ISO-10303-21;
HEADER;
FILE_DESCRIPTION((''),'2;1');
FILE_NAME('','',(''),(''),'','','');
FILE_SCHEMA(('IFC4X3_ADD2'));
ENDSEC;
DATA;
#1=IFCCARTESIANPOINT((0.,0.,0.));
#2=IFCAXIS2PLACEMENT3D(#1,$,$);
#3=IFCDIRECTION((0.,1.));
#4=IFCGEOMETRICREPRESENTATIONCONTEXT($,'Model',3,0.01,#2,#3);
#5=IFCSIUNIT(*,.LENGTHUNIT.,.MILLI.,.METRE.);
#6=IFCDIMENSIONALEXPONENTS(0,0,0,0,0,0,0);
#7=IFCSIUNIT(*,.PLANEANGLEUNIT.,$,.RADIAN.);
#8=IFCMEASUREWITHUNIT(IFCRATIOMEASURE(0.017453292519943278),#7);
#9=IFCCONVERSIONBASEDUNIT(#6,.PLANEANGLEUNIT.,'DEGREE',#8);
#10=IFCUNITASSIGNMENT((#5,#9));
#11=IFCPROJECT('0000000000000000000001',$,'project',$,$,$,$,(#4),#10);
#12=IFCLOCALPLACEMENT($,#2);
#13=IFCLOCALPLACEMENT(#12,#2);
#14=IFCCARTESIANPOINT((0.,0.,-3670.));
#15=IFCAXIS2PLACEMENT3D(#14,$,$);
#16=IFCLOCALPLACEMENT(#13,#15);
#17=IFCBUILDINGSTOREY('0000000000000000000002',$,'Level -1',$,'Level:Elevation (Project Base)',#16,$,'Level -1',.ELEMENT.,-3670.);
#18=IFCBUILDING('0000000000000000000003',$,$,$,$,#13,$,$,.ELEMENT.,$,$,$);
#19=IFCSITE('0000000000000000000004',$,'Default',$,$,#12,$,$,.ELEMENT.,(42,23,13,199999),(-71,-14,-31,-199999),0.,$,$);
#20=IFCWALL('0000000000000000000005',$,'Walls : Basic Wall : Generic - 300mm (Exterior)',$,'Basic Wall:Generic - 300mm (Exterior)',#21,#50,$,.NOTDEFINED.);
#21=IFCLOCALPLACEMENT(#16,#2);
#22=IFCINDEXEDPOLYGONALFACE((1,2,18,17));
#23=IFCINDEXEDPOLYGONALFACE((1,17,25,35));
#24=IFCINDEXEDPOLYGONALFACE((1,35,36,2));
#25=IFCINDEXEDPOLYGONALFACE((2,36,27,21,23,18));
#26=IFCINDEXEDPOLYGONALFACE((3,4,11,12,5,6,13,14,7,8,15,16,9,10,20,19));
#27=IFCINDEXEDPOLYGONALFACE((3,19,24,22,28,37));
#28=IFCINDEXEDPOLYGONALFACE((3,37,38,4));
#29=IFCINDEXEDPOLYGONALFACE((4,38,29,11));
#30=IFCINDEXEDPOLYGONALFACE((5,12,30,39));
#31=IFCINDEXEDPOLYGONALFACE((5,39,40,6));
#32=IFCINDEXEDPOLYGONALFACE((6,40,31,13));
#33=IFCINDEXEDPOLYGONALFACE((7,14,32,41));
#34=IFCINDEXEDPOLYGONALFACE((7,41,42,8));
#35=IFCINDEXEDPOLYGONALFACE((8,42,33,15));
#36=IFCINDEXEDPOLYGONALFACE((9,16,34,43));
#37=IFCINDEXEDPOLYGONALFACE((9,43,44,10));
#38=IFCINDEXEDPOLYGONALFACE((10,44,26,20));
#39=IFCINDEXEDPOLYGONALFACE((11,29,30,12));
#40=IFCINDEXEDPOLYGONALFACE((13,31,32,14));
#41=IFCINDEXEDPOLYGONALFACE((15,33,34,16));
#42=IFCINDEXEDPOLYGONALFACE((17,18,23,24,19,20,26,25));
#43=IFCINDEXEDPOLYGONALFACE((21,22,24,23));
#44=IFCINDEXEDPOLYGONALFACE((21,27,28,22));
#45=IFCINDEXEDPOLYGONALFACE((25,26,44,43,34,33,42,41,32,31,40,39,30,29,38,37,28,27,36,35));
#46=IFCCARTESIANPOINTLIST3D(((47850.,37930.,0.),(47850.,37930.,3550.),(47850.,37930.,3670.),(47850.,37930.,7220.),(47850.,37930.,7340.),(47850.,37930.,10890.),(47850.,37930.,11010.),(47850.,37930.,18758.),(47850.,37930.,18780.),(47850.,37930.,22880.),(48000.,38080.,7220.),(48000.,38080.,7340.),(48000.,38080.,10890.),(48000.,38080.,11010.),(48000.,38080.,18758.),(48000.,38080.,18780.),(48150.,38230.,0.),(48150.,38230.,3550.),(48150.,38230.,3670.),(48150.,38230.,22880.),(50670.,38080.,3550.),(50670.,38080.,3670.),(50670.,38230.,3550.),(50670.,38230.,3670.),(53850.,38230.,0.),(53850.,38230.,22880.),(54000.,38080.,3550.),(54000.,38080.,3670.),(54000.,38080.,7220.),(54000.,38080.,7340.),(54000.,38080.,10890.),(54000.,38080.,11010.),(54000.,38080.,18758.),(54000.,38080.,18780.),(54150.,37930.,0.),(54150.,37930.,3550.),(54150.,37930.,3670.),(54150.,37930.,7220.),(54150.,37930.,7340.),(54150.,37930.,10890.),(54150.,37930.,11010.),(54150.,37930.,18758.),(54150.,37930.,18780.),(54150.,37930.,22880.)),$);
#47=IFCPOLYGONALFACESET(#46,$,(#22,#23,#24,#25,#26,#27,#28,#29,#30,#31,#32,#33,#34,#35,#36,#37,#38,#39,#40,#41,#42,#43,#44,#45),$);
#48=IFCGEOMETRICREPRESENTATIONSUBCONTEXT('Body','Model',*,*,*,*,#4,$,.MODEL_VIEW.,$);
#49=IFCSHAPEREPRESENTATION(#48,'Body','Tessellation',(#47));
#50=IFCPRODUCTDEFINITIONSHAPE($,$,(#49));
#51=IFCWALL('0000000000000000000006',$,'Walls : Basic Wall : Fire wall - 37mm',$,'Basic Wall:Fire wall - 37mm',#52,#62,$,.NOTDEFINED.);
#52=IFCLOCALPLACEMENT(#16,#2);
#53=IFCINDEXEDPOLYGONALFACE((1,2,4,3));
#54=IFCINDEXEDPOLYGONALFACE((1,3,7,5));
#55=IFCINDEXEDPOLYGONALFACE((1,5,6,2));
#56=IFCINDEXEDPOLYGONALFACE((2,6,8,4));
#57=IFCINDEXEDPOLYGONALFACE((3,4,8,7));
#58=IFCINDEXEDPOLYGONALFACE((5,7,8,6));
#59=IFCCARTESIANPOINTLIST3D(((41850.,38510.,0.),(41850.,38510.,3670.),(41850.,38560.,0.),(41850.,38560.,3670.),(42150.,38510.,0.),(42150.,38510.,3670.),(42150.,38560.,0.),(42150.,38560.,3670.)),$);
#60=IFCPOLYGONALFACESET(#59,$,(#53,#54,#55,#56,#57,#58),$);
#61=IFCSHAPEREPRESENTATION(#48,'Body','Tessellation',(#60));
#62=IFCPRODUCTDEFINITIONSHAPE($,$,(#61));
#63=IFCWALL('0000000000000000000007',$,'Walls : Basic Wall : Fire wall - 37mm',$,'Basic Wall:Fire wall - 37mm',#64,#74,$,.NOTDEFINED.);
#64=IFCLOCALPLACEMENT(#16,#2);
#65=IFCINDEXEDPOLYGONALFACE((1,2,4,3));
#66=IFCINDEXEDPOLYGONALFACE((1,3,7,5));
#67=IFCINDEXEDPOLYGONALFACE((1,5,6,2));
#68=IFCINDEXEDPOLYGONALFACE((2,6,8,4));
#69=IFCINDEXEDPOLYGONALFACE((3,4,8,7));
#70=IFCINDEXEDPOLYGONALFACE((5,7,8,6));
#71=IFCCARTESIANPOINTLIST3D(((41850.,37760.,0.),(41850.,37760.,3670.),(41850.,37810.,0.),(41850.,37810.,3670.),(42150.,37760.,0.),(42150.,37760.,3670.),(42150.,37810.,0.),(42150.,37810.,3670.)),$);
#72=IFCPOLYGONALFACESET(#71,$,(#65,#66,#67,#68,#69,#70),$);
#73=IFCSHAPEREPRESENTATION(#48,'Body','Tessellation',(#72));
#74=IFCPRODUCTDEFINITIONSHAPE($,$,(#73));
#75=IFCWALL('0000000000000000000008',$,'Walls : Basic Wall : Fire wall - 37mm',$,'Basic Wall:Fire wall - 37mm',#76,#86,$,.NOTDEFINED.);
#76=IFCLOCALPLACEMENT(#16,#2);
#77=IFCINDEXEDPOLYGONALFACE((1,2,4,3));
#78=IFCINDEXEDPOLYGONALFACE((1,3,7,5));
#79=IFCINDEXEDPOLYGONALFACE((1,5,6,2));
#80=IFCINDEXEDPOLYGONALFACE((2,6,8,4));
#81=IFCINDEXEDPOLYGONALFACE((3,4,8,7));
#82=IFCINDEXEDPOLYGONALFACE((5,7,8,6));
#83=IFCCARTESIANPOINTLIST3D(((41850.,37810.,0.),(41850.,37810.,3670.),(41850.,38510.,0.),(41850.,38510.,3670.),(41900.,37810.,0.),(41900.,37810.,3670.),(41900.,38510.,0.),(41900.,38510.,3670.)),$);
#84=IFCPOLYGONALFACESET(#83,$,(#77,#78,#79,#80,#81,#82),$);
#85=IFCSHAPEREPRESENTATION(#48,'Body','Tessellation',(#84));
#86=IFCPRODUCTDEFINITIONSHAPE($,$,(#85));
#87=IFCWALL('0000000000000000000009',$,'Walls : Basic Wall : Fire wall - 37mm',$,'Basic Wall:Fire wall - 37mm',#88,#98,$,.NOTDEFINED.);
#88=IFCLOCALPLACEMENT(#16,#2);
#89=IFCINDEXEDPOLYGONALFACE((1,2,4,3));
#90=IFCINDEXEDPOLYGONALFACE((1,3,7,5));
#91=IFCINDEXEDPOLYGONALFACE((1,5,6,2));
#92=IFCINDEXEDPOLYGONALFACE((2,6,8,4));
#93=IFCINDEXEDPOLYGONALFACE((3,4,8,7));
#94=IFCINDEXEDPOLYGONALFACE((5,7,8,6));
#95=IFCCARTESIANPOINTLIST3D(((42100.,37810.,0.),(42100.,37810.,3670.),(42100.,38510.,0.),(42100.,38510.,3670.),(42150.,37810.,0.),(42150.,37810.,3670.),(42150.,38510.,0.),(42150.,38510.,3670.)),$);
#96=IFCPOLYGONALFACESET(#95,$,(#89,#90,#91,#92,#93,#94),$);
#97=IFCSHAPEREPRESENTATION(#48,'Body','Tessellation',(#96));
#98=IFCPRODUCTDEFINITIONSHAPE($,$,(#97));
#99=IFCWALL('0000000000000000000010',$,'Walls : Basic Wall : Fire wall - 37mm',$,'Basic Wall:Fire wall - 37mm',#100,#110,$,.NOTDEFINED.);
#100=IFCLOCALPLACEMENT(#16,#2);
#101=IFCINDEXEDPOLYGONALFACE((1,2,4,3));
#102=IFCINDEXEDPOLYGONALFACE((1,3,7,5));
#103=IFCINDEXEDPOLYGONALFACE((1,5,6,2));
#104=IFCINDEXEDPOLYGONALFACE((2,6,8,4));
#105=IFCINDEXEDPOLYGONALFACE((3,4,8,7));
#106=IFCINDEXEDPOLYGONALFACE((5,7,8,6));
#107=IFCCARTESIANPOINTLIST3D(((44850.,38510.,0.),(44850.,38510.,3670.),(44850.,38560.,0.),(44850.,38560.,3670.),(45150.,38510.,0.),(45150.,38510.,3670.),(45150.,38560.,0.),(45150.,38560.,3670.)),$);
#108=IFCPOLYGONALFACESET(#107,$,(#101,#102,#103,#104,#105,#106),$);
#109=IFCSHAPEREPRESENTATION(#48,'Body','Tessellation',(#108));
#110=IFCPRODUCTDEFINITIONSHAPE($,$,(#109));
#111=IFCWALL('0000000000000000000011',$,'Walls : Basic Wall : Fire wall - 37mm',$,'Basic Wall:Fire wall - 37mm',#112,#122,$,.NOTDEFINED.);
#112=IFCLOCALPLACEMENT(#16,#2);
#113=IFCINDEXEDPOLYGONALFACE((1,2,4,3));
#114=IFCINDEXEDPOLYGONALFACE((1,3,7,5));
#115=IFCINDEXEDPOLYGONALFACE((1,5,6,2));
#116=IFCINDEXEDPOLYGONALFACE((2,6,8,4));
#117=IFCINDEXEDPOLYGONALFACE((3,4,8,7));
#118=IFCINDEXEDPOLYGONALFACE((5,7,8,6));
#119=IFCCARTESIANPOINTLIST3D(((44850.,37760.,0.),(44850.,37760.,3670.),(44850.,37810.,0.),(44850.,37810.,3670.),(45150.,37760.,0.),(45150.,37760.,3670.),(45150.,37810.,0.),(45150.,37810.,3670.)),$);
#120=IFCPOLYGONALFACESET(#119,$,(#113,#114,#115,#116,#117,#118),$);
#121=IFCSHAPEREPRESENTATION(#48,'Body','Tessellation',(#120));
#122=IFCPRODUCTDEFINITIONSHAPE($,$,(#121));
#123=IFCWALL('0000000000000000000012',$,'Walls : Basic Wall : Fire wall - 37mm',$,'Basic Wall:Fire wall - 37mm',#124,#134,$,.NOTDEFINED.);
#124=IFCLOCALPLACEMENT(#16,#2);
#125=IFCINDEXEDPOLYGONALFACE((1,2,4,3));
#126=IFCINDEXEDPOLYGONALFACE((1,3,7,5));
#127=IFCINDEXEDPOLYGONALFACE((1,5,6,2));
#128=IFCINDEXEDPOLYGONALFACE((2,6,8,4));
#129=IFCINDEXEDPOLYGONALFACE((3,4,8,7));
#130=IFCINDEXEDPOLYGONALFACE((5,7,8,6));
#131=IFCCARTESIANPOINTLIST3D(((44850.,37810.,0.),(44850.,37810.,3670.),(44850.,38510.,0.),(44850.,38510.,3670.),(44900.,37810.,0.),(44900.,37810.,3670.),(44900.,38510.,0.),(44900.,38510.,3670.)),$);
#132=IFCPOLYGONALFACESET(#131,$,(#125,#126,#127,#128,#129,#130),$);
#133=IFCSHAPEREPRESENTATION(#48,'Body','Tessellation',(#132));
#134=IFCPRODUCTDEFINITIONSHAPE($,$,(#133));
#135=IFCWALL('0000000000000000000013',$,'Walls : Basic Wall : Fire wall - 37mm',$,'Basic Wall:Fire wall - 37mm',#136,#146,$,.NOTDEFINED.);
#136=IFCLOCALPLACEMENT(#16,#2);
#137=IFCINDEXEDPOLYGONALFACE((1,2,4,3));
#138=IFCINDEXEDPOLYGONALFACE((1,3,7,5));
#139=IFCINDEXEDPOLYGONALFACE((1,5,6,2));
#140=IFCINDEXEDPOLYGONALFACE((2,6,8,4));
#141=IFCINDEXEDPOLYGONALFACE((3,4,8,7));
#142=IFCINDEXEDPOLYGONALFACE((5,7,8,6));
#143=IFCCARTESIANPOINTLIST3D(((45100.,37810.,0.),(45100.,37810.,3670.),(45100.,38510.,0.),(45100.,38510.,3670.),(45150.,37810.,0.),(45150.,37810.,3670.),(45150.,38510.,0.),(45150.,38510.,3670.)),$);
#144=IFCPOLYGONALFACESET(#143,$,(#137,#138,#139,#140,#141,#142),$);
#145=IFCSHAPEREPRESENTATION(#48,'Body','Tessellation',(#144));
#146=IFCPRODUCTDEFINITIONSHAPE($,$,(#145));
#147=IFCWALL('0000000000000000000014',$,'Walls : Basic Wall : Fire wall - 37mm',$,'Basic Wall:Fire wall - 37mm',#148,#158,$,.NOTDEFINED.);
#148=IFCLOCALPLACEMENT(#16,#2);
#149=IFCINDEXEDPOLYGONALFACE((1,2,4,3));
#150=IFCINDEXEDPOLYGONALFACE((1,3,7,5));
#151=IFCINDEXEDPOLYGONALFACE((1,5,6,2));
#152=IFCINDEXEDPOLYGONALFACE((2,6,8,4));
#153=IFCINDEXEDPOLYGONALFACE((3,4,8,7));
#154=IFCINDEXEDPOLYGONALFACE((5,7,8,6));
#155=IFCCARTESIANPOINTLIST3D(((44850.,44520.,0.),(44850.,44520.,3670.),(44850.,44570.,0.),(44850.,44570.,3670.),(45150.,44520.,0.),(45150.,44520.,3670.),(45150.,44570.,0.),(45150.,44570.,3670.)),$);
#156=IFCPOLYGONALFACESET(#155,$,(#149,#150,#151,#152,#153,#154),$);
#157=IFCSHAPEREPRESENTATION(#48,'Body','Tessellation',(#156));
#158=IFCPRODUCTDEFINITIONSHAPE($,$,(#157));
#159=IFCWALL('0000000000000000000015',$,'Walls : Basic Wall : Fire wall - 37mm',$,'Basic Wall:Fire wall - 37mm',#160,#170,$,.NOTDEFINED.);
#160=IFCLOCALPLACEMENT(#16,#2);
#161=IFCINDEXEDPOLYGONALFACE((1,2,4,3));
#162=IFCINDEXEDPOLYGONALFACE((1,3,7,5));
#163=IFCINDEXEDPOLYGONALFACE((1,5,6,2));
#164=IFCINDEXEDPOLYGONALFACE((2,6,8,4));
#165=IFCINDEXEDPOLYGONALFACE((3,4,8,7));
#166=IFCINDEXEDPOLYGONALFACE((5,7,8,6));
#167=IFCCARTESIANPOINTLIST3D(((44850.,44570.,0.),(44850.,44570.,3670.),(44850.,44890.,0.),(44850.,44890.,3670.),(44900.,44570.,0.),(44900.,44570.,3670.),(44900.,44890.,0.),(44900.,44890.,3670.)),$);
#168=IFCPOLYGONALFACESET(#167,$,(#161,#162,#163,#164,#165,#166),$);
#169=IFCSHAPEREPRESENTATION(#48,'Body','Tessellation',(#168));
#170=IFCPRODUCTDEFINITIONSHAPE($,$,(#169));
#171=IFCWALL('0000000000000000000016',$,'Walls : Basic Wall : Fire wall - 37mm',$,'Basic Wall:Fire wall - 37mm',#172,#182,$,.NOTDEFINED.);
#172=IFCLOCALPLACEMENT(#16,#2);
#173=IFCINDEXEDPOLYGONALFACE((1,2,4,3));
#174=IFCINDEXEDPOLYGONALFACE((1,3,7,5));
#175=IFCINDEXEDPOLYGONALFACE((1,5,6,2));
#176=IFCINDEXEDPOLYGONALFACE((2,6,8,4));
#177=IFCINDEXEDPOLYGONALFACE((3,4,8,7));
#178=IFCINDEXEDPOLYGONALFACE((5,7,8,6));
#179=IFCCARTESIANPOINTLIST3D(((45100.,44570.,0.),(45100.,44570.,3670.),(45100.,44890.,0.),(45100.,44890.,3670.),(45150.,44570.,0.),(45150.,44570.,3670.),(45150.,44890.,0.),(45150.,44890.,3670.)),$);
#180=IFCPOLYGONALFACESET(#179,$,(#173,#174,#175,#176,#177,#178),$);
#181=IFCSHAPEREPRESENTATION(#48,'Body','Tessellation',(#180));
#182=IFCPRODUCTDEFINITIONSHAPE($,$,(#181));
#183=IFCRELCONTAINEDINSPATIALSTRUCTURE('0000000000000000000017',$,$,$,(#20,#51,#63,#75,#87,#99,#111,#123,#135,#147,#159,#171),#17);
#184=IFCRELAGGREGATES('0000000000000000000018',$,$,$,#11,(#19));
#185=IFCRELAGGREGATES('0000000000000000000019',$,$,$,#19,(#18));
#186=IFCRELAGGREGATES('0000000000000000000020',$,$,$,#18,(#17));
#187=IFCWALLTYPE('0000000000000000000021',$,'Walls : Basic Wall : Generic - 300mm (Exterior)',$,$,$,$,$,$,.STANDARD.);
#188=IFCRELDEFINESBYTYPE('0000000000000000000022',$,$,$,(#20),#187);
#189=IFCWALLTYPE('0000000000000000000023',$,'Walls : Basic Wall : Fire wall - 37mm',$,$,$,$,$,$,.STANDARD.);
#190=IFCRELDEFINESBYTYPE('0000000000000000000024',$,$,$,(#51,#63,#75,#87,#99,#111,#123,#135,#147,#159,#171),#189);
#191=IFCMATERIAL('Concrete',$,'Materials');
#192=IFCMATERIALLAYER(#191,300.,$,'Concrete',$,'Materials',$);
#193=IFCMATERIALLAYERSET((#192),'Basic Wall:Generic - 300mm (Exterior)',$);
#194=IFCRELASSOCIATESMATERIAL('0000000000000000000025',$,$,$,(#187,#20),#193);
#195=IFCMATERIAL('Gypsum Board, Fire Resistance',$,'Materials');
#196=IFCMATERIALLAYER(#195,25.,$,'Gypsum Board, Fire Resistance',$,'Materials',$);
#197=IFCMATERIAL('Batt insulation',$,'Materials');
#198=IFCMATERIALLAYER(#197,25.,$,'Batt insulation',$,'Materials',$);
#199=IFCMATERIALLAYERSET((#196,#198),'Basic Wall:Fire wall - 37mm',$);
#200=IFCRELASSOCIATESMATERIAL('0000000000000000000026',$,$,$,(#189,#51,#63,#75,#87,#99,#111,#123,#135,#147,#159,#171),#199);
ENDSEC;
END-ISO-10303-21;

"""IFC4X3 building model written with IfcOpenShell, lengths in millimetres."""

from ifc_helpers import new_model, entity, si_unit, converted_unit, direction, frame, frame_2d, origin, place, context, subcontext, project, spatial, polyline, rectangle, outline, extrude, material, layer, layer_set, type_object, element, save


model = new_model("IFC4X3")

# Units and contexts
model_context = context("Model", 3, precision=0.01, world=origin(), true_north=direction((0.0, 1.0)))
body_context = subcontext(model_context, "Body", "Model", "MODEL_VIEW")
ifc_project = project(units=[si_unit("LENGTHUNIT", "METRE", prefix="MILLI"), converted_unit("PLANEANGLEUNIT", "DEGREE", entity("IfcRatioMeasure", 0.017453292519943278), si_unit("PLANEANGLEUNIT", "RADIAN"), dimensions=[0, 0, 0, 0, 0, 0, 0])], contexts=[model_context])

# Site, building, storey
site_placement = place(None, origin())
site = spatial("IfcSite", under=ifc_project, at=site_placement, Name="Default", CompositionType="ELEMENT", RefLatitude=(42, 23, 13, 199999), RefLongitude=(-71, -14, -31, -199999), RefElevation=0.0)
building_placement = place(site_placement, origin())
building = spatial("IfcBuilding", under=site, at=building_placement, CompositionType="ELEMENT")
storey_placement = place(building_placement, frame((0.0, 0.0, -3670.0)))
storey = spatial("IfcBuildingStorey", under=building, at=storey_placement, Name="Level -1", ObjectType="Level:Elevation (Project Base)", LongName="Level -1", CompositionType="ELEMENT", Elevation=-3670.0)

# Wall, openings
ifc_material_1 = material(Name="Concrete", Category="Materials")
ifc_layer_1 = layer(ifc_material_1, 300.0, Name="Concrete", Category="Materials")
ifc_layer_set_1 = layer_set([ifc_layer_1], Name="Basic Wall:Generic - 300mm (Exterior)")
wall_type_1 = type_object("IfcWallType", Name="Walls : Basic Wall : Generic - 300mm (Exterior)", PredefinedType="STANDARD", material=ifc_layer_set_1)
wall_1_placement = place(storey_placement, frame((47850.0, 38080.0, 0.0)))
wall_1 = element("IfcWall", 1, at=wall_1_placement, inside=storey, type_object=wall_type_1, material=ifc_layer_set_1, Name="Walls : Basic Wall : Generic - 300mm (Exterior)", ObjectType="Basic Wall:Generic - 300mm (Exterior)", PredefinedType="NOTDEFINED", context=body_context, shape_type="SweptSolid", body=[
    extrude(outline(polyline([(6300.0, -150.0), (6000.0, 150.0), (300.0, 150.0), (0.0, -150.0), (6300.0, -150.0)])), origin(), (0.0, 0.0, 1.0), 22880.0),
])
opening_1_placement = place(storey_placement, frame((47850.0, 38080.0, 0.0)))
element("IfcOpeningElement", 2, at=opening_1_placement, cuts=wall_1, PredefinedType="OPENING", context=body_context, shape_type="SweptSolid", body=[
    extrude(outline(polyline([(-3000.0, -75.0), (3000.0, -75.0), (3150.0, 75.0), (-3150.0, 75.0), (-3000.0, -75.0)])), frame((3150.0, -75.0, 18758.0), z_axis=(0.0, 0.0, 1.0), x_axis=(-1.0, 0.0, 0.0)), (0.0, 0.0, 1.0), 22.0),
])
opening_2_placement = place(storey_placement, frame((47850.0, 38080.0, 0.0)))
element("IfcOpeningElement", 3, at=opening_2_placement, cuts=wall_1, PredefinedType="OPENING", context=body_context, shape_type="SweptSolid", body=[
    extrude(outline(polyline([(-3000.0, -75.0), (3000.0, -75.0), (3150.0, 75.0), (-3150.0, 75.0), (-3000.0, -75.0)])), frame((3150.0, -75.0, 10890.0), z_axis=(0.0, 0.0, 1.0), x_axis=(-1.0, 0.0, 0.0)), (0.0, 0.0, 1.0), 120.0),
])
opening_3_placement = place(storey_placement, frame((47850.0, 38080.0, 0.0)))
element("IfcOpeningElement", 4, at=opening_3_placement, cuts=wall_1, PredefinedType="OPENING", context=body_context, shape_type="SweptSolid", body=[
    extrude(outline(polyline([(-3000.0, -75.0), (3000.0, -75.0), (3150.0, 75.0), (-3150.0, 75.0), (-3000.0, -75.0)])), frame((3150.0, -75.0, 7220.0), z_axis=(0.0, 0.0, 1.0), x_axis=(-1.0, 0.0, 0.0)), (0.0, 0.0, 1.0), 120.0),
])
opening_4_placement = place(storey_placement, frame((47850.0, 38080.0, 0.0)))
element("IfcOpeningElement", 5, at=opening_4_placement, cuts=wall_1, PredefinedType="OPENING", context=body_context, shape_type="SweptSolid", body=[
    extrude(outline(polyline([(-3085.0, 0.0), (-3235.0, -150.0), (3065.0, -150.0), (2765.0, 150.0), (245.0, 150.0), (245.0, 0.0), (-3085.0, 0.0)])), frame((3065.0, 0.0, 3550.0), z_axis=(0.0, 0.0, -1.0), x_axis=(-1.0, 0.0, 0.0)), (0.0, 0.0, -1.0), 120.0),
])

# Walls
ifc_material_2 = material(Name="Gypsum Board, Fire Resistance", Category="Materials")
ifc_layer_2 = layer(ifc_material_2, 25.0, Name="Gypsum Board, Fire Resistance", Category="Materials")
ifc_material_3 = material(Name="Batt insulation", Category="Materials")
ifc_layer_3 = layer(ifc_material_3, 25.0, Name="Batt insulation", Category="Materials")
ifc_layer_set_2 = layer_set([ifc_layer_2, ifc_layer_3], Name="Basic Wall:Fire wall - 37mm")
wall_type_2 = type_object("IfcWallType", Name="Walls : Basic Wall : Fire wall - 37mm", PredefinedType="STANDARD", material=ifc_layer_set_2)
for number, where, name in (
    (6, (41850.0, 38535.0, 0.0), "Walls : Basic Wall : Fire wall - 37mm"),
    (7, (41850.0, 37785.0, 0.0), "Walls : Basic Wall : Fire wall - 37mm"),
):
    element("IfcWall", number, at=place(storey_placement, frame(where)), inside=storey, type_object=wall_type_2, material=ifc_layer_set_2, Name=name, ObjectType="Basic Wall:Fire wall - 37mm", PredefinedType="NOTDEFINED", context=body_context, shape_type="SweptSolid", body=[
        extrude(rectangle(XDim=300.0, YDim=50.0, at=frame_2d((150.0, 0.0), x_axis=(-1.0, 0.0))), origin(), (0.0, 0.0, 1.0), 3670.0),
    ])
for number, where, z_axis, x_axis, name in (
    (8, (41875.0, 38510.0, 0.0), (0.0, 0.0, 1.0), (0.0, -1.0, 0.0), "Walls : Basic Wall : Fire wall - 37mm"),
    (9, (42125.0, 38510.0, 0.0), (0.0, 0.0, 1.0), (0.0, -1.0, 0.0), "Walls : Basic Wall : Fire wall - 37mm"),
):
    element("IfcWall", number, at=place(storey_placement, frame(where, z_axis=z_axis, x_axis=x_axis)), inside=storey, type_object=wall_type_2, material=ifc_layer_set_2, Name=name, ObjectType="Basic Wall:Fire wall - 37mm", PredefinedType="NOTDEFINED", context=body_context, shape_type="SweptSolid", body=[
        extrude(rectangle(XDim=700.0, YDim=50.0, at=frame_2d((350.0, 0.0), x_axis=(-1.0, 0.0))), origin(), (0.0, 0.0, 1.0), 3670.0),
    ])
for number, where, name in (
    (10, (44850.0, 38535.0, 0.0), "Walls : Basic Wall : Fire wall - 37mm"),
    (11, (44850.0, 37785.0, 0.0), "Walls : Basic Wall : Fire wall - 37mm"),
):
    element("IfcWall", number, at=place(storey_placement, frame(where)), inside=storey, type_object=wall_type_2, material=ifc_layer_set_2, Name=name, ObjectType="Basic Wall:Fire wall - 37mm", PredefinedType="NOTDEFINED", context=body_context, shape_type="SweptSolid", body=[
        extrude(rectangle(XDim=300.0, YDim=50.0, at=frame_2d((150.0, 0.0), x_axis=(-1.0, 0.0))), origin(), (0.0, 0.0, 1.0), 3670.0),
    ])
for number, where, z_axis, x_axis, name in (
    (12, (44875.0, 38510.0, 0.0), (0.0, 0.0, 1.0), (0.0, -1.0, 0.0), "Walls : Basic Wall : Fire wall - 37mm"),
    (13, (45125.0, 38510.0, 0.0), (0.0, 0.0, 1.0), (0.0, -1.0, 0.0), "Walls : Basic Wall : Fire wall - 37mm"),
):
    element("IfcWall", number, at=place(storey_placement, frame(where, z_axis=z_axis, x_axis=x_axis)), inside=storey, type_object=wall_type_2, material=ifc_layer_set_2, Name=name, ObjectType="Basic Wall:Fire wall - 37mm", PredefinedType="NOTDEFINED", context=body_context, shape_type="SweptSolid", body=[
        extrude(rectangle(XDim=700.0, YDim=50.0, at=frame_2d((350.0, 0.0), x_axis=(-1.0, 0.0))), origin(), (0.0, 0.0, 1.0), 3670.0),
    ])
wall_2_placement = place(storey_placement, frame((44850.0, 44545.0, 0.0)))
element("IfcWall", 14, at=wall_2_placement, inside=storey, type_object=wall_type_2, material=ifc_layer_set_2, Name="Walls : Basic Wall : Fire wall - 37mm", ObjectType="Basic Wall:Fire wall - 37mm", PredefinedType="NOTDEFINED", context=body_context, shape_type="SweptSolid", body=[
    extrude(rectangle(XDim=300.0, YDim=50.0, at=frame_2d((150.0, 0.0), x_axis=(-1.0, 0.0))), origin(), (0.0, 0.0, 1.0), 3670.0),
])
wall_3_placement = place(storey_placement, frame((44875.0, 44890.0, 0.0), z_axis=(0.0, 0.0, 1.0), x_axis=(0.0, -1.0, 0.0)))
element("IfcWall", 15, at=wall_3_placement, inside=storey, type_object=wall_type_2, material=ifc_layer_set_2, Name="Walls : Basic Wall : Fire wall - 37mm", ObjectType="Basic Wall:Fire wall - 37mm", PredefinedType="NOTDEFINED", context=body_context, shape_type="SweptSolid", body=[
    extrude(rectangle(XDim=320.0, YDim=50.0, at=frame_2d((160.0, 0.0), x_axis=(-1.0, 0.0))), origin(), (0.0, 0.0, 1.0), 3670.0),
])
wall_4_placement = place(storey_placement, frame((45125.0, 44890.0, 0.0), z_axis=(0.0, 0.0, 1.0), x_axis=(0.0, -1.0, 0.0)))
element("IfcWall", 16, at=wall_4_placement, inside=storey, type_object=wall_type_2, material=ifc_layer_set_2, Name="Walls : Basic Wall : Fire wall - 37mm", ObjectType="Basic Wall:Fire wall - 37mm", PredefinedType="NOTDEFINED", context=body_context, shape_type="SweptSolid", body=[
    extrude(rectangle(XDim=320.0, YDim=50.0, at=frame_2d((160.0, 0.0), x_axis=(-1.0, 0.0))), origin(), (0.0, 0.0, 1.0), 3670.0),
])

save(model, "model.ifc")
